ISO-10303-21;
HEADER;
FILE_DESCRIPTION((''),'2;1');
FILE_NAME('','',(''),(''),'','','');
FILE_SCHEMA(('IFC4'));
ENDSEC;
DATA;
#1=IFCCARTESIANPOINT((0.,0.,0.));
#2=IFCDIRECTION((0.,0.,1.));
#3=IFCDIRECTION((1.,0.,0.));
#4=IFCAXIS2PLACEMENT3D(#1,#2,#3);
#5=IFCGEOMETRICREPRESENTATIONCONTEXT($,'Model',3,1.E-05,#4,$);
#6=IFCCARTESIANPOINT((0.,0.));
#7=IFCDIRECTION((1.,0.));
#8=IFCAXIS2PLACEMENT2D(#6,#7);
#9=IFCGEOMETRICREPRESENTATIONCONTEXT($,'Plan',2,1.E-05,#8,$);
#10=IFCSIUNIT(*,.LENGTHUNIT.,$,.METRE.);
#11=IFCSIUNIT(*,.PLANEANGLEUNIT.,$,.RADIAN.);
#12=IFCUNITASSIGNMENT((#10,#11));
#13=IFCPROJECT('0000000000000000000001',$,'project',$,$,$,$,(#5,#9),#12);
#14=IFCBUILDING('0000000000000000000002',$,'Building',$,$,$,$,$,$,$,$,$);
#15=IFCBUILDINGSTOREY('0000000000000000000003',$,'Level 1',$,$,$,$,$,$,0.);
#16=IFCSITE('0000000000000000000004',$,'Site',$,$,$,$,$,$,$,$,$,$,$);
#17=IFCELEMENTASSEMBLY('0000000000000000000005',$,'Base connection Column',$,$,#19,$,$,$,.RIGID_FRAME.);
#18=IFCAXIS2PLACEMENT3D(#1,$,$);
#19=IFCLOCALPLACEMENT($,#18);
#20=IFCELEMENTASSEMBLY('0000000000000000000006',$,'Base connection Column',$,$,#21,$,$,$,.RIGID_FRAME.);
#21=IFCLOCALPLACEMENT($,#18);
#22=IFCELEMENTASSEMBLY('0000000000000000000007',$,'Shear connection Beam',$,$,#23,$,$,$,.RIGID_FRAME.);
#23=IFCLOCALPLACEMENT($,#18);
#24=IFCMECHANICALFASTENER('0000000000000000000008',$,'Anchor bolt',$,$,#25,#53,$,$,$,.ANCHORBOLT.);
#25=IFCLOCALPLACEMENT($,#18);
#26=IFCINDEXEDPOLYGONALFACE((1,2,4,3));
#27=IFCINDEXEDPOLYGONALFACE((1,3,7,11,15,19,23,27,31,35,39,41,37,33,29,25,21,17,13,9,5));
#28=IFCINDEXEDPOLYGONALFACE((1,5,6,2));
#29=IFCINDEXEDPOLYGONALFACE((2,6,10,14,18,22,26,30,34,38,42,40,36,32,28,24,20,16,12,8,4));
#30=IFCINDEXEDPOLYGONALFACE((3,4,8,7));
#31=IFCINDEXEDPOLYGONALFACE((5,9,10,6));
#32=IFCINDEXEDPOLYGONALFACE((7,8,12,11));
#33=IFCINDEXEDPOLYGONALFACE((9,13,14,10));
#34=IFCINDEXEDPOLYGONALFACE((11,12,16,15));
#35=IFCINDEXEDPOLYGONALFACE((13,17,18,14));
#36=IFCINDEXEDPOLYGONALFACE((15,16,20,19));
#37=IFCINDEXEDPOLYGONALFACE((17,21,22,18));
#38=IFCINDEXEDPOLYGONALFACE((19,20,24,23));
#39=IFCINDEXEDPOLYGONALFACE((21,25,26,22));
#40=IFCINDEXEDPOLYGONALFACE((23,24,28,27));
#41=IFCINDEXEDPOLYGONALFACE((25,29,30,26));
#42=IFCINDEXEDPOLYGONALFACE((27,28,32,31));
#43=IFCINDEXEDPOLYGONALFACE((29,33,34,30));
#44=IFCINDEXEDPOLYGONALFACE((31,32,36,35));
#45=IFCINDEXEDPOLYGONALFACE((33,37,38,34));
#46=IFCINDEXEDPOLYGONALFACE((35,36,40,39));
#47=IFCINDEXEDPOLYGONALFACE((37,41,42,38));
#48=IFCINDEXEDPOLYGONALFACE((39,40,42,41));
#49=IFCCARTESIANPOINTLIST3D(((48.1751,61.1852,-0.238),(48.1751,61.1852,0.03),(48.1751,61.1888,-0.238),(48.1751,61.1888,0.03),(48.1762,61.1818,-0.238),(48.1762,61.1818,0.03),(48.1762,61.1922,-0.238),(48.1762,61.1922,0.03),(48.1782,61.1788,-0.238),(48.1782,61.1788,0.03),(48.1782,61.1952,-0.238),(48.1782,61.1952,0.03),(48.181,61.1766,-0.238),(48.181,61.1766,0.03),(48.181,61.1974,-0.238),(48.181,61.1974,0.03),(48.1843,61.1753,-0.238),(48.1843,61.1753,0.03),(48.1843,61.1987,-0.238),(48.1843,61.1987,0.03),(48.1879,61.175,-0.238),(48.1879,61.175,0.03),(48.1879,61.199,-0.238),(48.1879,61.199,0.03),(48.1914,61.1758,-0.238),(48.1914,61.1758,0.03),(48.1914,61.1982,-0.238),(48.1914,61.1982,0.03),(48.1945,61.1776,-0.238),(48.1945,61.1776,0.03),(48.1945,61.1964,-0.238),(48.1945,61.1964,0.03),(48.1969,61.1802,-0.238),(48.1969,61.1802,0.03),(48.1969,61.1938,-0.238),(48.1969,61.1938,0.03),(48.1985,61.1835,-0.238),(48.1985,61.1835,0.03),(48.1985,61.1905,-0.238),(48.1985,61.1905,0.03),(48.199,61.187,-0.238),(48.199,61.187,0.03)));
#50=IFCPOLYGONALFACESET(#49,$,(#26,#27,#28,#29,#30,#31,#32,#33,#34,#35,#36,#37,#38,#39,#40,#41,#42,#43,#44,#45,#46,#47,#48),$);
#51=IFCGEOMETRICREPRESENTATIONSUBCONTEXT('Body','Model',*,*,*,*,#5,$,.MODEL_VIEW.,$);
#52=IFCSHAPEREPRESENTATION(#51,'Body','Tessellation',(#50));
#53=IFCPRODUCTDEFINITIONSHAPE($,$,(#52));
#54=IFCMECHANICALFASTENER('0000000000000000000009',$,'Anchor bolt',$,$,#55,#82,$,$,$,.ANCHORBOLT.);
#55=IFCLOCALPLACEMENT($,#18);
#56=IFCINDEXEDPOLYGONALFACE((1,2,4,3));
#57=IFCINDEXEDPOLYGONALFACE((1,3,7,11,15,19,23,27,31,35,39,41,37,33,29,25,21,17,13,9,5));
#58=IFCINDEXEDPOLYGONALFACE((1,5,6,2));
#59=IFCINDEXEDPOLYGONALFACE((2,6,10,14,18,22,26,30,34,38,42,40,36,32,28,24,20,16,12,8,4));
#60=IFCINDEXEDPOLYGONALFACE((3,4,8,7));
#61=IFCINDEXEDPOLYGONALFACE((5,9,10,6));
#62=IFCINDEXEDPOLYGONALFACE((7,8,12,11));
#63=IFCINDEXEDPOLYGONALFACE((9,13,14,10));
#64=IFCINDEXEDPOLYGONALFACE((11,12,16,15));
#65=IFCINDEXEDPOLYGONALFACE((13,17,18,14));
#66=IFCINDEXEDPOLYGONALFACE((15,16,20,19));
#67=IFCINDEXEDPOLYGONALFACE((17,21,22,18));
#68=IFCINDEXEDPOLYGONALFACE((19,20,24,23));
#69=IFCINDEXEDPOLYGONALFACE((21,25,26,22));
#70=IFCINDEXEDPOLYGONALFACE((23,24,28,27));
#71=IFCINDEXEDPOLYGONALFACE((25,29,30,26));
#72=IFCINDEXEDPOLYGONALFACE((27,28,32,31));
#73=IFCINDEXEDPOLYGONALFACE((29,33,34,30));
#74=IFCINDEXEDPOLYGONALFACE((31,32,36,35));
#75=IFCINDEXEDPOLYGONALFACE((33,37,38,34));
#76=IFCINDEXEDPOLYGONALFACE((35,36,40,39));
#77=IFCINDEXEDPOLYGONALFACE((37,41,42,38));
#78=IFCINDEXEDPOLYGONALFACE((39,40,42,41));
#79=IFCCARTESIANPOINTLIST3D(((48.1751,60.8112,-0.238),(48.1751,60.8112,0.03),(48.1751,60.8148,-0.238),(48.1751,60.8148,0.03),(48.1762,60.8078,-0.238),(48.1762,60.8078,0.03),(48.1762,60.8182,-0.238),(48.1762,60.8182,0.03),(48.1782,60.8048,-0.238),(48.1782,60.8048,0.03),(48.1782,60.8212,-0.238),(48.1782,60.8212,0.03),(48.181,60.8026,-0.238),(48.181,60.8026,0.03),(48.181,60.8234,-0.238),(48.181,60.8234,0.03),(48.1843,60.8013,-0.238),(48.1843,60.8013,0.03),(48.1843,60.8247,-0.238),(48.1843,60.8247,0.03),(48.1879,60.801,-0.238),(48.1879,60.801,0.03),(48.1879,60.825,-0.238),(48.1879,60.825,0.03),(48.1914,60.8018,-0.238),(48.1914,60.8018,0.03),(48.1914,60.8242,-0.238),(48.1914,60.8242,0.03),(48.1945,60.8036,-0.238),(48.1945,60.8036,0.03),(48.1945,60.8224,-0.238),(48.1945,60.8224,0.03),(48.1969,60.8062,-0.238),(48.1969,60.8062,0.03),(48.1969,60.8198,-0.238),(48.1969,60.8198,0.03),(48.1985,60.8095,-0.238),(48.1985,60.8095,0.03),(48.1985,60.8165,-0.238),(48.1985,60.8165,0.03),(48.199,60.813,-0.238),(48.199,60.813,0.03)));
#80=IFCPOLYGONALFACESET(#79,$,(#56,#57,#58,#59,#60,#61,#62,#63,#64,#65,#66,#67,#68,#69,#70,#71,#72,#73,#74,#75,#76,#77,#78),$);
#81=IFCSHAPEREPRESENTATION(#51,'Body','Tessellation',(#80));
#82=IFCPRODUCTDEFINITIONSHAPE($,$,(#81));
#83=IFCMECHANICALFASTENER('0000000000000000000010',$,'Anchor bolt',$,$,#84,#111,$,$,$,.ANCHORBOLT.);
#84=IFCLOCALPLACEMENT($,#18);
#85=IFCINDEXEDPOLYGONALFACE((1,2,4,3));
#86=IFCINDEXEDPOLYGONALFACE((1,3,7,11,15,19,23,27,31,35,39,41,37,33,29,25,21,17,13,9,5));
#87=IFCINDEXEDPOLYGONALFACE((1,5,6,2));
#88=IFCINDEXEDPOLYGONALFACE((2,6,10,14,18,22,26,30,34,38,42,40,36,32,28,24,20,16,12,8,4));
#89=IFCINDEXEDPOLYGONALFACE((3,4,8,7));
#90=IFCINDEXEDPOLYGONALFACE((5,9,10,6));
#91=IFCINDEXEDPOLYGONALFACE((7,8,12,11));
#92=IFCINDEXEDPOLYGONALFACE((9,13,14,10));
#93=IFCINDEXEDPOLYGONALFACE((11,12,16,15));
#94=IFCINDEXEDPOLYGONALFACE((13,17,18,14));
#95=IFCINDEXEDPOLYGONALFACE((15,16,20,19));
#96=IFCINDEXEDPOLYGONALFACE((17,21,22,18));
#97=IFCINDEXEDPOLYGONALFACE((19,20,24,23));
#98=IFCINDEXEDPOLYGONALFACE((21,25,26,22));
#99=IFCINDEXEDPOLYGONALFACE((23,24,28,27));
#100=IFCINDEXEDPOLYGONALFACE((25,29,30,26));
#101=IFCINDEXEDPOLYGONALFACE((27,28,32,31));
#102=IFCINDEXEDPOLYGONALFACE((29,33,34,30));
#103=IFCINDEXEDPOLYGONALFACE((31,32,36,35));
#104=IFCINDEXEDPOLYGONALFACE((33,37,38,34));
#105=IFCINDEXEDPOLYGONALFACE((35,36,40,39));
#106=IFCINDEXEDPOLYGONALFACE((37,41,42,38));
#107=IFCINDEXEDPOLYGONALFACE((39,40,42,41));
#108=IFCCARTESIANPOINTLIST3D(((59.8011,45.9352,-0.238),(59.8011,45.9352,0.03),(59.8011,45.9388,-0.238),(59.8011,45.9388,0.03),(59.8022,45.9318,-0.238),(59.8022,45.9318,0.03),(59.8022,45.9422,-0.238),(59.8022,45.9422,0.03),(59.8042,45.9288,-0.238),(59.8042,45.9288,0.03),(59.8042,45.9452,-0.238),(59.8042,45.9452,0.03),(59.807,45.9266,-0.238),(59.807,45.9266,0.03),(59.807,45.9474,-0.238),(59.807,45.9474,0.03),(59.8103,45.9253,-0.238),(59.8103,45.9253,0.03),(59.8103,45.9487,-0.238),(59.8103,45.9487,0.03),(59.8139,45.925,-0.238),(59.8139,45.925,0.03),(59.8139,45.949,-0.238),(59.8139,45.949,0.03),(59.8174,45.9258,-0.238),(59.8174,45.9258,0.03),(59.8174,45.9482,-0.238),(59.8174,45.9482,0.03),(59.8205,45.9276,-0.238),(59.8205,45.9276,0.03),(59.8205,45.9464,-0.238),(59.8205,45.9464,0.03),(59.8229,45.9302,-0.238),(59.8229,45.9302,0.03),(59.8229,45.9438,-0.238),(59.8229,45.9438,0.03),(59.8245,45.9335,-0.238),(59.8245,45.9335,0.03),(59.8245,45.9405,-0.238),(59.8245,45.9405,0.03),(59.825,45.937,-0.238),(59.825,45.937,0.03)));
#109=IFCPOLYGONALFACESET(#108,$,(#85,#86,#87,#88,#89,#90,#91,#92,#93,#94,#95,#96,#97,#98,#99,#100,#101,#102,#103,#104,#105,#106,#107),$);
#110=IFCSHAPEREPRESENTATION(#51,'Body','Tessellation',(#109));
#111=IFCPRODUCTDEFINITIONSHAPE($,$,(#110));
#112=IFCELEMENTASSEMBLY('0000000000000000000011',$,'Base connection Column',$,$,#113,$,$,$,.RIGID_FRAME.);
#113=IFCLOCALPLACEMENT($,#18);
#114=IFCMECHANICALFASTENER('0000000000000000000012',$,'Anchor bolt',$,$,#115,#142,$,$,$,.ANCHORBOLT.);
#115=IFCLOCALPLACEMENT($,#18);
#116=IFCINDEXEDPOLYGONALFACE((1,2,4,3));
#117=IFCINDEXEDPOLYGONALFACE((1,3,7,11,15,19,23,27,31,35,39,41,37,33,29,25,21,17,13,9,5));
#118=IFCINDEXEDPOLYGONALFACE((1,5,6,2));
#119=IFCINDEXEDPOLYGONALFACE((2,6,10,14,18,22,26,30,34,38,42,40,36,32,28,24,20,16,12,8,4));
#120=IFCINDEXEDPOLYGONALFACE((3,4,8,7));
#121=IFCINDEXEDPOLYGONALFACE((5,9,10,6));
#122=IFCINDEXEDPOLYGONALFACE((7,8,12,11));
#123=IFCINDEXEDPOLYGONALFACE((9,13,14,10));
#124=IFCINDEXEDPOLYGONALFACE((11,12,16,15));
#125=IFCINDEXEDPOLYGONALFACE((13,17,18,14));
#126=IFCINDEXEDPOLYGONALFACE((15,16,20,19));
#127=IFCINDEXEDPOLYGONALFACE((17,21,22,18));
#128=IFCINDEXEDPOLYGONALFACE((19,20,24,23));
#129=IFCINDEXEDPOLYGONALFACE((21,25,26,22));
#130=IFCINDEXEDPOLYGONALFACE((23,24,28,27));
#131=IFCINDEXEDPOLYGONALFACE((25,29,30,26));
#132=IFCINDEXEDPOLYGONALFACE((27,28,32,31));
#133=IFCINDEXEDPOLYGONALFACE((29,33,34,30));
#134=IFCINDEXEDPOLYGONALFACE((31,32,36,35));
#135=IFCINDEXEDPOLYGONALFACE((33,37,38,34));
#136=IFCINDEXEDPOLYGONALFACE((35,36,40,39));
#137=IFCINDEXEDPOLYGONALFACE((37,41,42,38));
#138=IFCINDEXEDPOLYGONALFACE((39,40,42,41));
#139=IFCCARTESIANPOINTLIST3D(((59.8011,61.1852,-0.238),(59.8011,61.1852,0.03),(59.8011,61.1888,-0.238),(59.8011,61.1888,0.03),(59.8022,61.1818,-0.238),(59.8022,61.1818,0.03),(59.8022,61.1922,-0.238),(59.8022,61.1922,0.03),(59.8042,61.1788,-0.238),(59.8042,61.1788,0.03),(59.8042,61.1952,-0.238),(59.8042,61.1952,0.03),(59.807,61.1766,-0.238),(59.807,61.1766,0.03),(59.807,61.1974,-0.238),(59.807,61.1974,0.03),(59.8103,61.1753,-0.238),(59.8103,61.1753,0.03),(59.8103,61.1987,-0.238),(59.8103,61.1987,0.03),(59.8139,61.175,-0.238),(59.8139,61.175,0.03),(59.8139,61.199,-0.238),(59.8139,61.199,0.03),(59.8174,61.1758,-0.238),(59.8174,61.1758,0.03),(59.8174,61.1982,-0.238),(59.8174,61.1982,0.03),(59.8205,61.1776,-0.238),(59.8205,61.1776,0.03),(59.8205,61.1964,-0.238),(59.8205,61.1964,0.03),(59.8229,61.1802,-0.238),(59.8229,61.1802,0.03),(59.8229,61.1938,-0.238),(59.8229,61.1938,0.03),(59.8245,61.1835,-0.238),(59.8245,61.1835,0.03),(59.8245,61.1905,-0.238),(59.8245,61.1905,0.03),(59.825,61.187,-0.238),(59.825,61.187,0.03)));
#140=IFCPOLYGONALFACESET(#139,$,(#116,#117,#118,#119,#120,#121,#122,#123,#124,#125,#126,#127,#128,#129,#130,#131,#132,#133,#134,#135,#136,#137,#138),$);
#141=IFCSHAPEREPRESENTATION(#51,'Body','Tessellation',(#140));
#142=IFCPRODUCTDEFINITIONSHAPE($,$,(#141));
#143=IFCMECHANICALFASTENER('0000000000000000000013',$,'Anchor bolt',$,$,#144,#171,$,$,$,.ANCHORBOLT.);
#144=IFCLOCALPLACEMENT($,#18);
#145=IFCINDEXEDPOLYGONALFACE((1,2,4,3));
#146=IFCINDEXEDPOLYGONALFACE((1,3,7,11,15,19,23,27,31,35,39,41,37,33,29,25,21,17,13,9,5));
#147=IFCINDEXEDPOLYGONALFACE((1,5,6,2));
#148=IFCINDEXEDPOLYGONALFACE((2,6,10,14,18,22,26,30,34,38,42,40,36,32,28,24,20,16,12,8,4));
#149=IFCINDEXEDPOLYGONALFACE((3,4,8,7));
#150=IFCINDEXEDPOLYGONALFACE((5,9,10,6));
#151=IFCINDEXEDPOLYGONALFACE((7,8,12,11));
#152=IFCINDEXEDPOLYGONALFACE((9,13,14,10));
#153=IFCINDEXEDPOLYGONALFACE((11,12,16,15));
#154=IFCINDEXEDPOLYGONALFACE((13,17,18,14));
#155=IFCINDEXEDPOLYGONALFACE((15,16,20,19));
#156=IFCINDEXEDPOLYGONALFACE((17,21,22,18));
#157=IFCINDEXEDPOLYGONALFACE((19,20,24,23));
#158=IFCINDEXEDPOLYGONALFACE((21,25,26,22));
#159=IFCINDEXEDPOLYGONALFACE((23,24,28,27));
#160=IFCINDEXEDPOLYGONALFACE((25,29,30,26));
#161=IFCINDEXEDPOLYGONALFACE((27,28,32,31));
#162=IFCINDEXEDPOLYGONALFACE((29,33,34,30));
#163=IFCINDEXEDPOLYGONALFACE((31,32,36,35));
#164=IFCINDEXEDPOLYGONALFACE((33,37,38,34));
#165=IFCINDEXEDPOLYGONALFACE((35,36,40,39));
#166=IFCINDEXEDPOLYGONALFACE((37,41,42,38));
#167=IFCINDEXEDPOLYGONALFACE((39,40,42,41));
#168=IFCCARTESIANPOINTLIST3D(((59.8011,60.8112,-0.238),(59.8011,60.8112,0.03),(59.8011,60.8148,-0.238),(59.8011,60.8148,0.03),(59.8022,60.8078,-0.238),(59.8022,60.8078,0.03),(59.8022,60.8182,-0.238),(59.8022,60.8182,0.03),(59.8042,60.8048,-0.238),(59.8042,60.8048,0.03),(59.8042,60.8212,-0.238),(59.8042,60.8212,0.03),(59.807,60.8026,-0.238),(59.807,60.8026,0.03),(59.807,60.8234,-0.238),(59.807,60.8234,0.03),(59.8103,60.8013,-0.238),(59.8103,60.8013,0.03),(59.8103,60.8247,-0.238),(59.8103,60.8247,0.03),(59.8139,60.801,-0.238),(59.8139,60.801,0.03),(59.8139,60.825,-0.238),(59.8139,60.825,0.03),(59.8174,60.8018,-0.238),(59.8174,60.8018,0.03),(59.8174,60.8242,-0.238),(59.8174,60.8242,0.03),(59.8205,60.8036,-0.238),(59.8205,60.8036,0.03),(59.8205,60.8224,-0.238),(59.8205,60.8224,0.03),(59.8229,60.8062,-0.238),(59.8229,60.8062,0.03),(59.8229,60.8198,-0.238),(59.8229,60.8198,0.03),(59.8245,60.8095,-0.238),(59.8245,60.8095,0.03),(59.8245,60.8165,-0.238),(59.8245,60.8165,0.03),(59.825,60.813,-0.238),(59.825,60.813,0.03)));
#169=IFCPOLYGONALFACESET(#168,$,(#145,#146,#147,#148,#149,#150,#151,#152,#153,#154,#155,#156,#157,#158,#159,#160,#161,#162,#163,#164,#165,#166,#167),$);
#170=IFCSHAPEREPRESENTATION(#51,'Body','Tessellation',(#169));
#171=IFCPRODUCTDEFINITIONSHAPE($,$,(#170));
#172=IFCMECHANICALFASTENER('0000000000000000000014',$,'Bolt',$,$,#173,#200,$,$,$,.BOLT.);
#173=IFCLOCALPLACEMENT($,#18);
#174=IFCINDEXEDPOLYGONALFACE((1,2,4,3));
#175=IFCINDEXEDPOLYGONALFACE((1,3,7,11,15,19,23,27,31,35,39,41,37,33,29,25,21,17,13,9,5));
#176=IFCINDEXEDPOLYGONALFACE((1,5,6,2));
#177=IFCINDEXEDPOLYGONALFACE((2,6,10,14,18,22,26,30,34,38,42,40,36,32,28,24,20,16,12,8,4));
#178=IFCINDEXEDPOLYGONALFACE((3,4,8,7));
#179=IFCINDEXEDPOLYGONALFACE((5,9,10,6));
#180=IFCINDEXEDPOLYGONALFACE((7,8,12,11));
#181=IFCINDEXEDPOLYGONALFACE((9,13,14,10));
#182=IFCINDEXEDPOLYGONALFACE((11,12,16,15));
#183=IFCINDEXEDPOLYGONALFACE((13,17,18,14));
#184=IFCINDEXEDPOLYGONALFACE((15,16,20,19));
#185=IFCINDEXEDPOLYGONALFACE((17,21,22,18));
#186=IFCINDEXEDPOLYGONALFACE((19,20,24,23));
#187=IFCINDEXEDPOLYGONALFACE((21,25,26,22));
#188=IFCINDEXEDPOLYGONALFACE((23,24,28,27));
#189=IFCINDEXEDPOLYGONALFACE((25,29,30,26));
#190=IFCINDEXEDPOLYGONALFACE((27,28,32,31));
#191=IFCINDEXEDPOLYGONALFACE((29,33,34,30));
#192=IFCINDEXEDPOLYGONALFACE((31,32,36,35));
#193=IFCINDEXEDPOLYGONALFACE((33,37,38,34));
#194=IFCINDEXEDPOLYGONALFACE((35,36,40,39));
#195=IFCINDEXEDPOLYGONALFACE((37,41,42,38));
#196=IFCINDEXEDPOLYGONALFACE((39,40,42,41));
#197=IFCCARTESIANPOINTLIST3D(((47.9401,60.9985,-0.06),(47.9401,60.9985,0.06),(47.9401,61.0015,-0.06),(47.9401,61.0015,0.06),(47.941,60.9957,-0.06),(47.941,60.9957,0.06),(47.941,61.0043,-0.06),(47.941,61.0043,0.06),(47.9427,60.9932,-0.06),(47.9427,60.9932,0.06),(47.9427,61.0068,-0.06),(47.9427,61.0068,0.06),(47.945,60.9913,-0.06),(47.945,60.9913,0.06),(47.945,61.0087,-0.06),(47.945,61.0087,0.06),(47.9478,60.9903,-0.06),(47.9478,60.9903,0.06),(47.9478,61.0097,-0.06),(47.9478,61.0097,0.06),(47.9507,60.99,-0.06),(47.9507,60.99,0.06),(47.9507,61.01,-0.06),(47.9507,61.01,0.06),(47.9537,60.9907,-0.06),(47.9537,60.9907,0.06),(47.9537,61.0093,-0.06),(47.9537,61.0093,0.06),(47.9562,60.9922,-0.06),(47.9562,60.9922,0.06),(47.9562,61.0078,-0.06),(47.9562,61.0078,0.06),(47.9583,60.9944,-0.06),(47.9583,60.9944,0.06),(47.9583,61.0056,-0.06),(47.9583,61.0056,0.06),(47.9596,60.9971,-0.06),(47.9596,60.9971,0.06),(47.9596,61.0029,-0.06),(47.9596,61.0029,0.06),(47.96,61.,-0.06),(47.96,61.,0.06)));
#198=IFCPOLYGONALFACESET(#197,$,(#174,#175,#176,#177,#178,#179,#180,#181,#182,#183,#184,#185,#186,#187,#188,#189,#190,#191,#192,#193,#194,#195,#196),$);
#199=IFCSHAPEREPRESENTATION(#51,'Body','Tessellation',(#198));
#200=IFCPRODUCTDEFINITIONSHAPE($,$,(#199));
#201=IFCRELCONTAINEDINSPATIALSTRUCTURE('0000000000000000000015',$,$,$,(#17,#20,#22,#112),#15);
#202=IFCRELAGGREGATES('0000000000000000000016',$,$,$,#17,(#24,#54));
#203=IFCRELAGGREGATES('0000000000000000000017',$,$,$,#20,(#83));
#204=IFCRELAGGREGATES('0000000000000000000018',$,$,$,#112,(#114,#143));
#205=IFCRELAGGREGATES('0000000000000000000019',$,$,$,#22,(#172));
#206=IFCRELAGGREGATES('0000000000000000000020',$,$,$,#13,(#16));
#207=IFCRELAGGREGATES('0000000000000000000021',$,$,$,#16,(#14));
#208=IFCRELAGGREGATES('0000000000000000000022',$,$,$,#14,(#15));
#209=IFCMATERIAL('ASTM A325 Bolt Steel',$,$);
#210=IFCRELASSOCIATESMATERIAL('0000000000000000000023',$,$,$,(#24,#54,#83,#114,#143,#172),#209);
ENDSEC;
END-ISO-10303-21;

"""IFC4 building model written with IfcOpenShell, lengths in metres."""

from ifc_helpers import new_model, si_unit, frame, origin_with_axes, origin_2d, origin_2d_with_axis, place, context, subcontext, project, spatial, circle, extrude, material, element, aggregate, save


model = new_model("IFC4")

# Units and contexts
model_context = context("Model", 3, precision=1e-05, world=origin_with_axes())
plan_context = context("Plan", 2, precision=1e-05, world=origin_2d_with_axis())
body_context = subcontext(model_context, "Body", "Model", "MODEL_VIEW")
ifc_project = project(units=[si_unit("LENGTHUNIT", "METRE"), si_unit("PLANEANGLEUNIT", "RADIAN")], contexts=[model_context, plan_context])

# Site, building, storey
site = spatial("IfcSite", under=ifc_project, Name="Site")
building = spatial("IfcBuilding", under=site, Name="Building")
storey = spatial("IfcBuildingStorey", under=building, Name="Level 1", Elevation=0.0)

# Element assemblies
assembly_1 = element("IfcElementAssembly", 1, inside=storey, Name="Base connection Column", PredefinedType="RIGID_FRAME")
assembly_2 = element("IfcElementAssembly", 2, inside=storey, Name="Base connection Column", PredefinedType="RIGID_FRAME")

# Element assembly
assembly_3 = element("IfcElementAssembly", 3, inside=storey, Name="Shear connection Beam", PredefinedType="RIGID_FRAME")

# Shared definitions
ifc_material_1 = material(Name="ASTM A325 Bolt Steel")

# Mechanical fasteners
mechanical_fastener_1_placement = place(None, frame((48.187, 61.187, -0.238), z_axis=(0.0, 0.0, 1.0), x_axis=(1.0, 0.0, 0.0)))
mechanical_fastener_1 = element("IfcMechanicalFastener", 4, at=mechanical_fastener_1_placement, material=ifc_material_1, Name="Anchor bolt", PredefinedType="ANCHORBOLT", context=body_context, shape_type="SweptSolid", body=[
    extrude(circle(Radius=0.012, at=origin_2d()), origin_with_axes(), (0.0, 0.0, 1.0), 0.268),
])
mechanical_fastener_2_placement = place(None, frame((48.187, 60.813, -0.238), z_axis=(0.0, 0.0, 1.0), x_axis=(1.0, 0.0, 0.0)))
mechanical_fastener_2 = element("IfcMechanicalFastener", 5, at=mechanical_fastener_2_placement, material=ifc_material_1, Name="Anchor bolt", PredefinedType="ANCHORBOLT", context=body_context, shape_type="SweptSolid", body=[
    extrude(circle(Radius=0.012, at=origin_2d()), origin_with_axes(), (0.0, 0.0, 1.0), 0.268),
])
aggregate(assembly_1, [mechanical_fastener_1, mechanical_fastener_2])
mechanical_fastener_3_placement = place(None, frame((59.813, 45.937, -0.238), z_axis=(0.0, 0.0, 1.0), x_axis=(1.0, 0.0, 0.0)))
mechanical_fastener_3 = element("IfcMechanicalFastener", 6, at=mechanical_fastener_3_placement, material=ifc_material_1, Name="Anchor bolt", PredefinedType="ANCHORBOLT", context=body_context, shape_type="SweptSolid", body=[
    extrude(circle(Radius=0.012, at=origin_2d()), origin_with_axes(), (0.0, 0.0, 1.0), 0.268),
])
aggregate(assembly_2, [mechanical_fastener_3])

# Element assembly, mechanical fasteners
assembly_4 = element("IfcElementAssembly", 7, inside=storey, Name="Base connection Column", PredefinedType="RIGID_FRAME")
mechanical_fastener_4_placement = place(None, frame((59.813, 61.187, -0.238), z_axis=(0.0, 0.0, 1.0), x_axis=(1.0, 0.0, 0.0)))
mechanical_fastener_4 = element("IfcMechanicalFastener", 8, at=mechanical_fastener_4_placement, material=ifc_material_1, Name="Anchor bolt", PredefinedType="ANCHORBOLT", context=body_context, shape_type="SweptSolid", body=[
    extrude(circle(Radius=0.012, at=origin_2d()), origin_with_axes(), (0.0, 0.0, 1.0), 0.268),
])
mechanical_fastener_5_placement = place(None, frame((59.813, 60.813, -0.238), z_axis=(0.0, 0.0, 1.0), x_axis=(1.0, 0.0, 0.0)))
mechanical_fastener_5 = element("IfcMechanicalFastener", 9, at=mechanical_fastener_5_placement, material=ifc_material_1, Name="Anchor bolt", PredefinedType="ANCHORBOLT", context=body_context, shape_type="SweptSolid", body=[
    extrude(circle(Radius=0.012, at=origin_2d()), origin_with_axes(), (0.0, 0.0, 1.0), 0.268),
])
aggregate(assembly_4, [mechanical_fastener_4, mechanical_fastener_5])

# Mechanical fastener
mechanical_fastener_6_placement = place(None, frame((47.95, 61.0, -0.06), z_axis=(0.0, 0.0, 1.0), x_axis=(1.0, 0.0, 0.0)))
mechanical_fastener_6 = element("IfcMechanicalFastener", 10, at=mechanical_fastener_6_placement, material=ifc_material_1, Name="Bolt", PredefinedType="BOLT", context=body_context, shape_type="SweptSolid", body=[
    extrude(circle(Radius=0.01, at=origin_2d()), origin_with_axes(), (0.0, 0.0, 1.0), 0.12),
])
aggregate(assembly_3, [mechanical_fastener_6])

save(model, "model.ifc")
